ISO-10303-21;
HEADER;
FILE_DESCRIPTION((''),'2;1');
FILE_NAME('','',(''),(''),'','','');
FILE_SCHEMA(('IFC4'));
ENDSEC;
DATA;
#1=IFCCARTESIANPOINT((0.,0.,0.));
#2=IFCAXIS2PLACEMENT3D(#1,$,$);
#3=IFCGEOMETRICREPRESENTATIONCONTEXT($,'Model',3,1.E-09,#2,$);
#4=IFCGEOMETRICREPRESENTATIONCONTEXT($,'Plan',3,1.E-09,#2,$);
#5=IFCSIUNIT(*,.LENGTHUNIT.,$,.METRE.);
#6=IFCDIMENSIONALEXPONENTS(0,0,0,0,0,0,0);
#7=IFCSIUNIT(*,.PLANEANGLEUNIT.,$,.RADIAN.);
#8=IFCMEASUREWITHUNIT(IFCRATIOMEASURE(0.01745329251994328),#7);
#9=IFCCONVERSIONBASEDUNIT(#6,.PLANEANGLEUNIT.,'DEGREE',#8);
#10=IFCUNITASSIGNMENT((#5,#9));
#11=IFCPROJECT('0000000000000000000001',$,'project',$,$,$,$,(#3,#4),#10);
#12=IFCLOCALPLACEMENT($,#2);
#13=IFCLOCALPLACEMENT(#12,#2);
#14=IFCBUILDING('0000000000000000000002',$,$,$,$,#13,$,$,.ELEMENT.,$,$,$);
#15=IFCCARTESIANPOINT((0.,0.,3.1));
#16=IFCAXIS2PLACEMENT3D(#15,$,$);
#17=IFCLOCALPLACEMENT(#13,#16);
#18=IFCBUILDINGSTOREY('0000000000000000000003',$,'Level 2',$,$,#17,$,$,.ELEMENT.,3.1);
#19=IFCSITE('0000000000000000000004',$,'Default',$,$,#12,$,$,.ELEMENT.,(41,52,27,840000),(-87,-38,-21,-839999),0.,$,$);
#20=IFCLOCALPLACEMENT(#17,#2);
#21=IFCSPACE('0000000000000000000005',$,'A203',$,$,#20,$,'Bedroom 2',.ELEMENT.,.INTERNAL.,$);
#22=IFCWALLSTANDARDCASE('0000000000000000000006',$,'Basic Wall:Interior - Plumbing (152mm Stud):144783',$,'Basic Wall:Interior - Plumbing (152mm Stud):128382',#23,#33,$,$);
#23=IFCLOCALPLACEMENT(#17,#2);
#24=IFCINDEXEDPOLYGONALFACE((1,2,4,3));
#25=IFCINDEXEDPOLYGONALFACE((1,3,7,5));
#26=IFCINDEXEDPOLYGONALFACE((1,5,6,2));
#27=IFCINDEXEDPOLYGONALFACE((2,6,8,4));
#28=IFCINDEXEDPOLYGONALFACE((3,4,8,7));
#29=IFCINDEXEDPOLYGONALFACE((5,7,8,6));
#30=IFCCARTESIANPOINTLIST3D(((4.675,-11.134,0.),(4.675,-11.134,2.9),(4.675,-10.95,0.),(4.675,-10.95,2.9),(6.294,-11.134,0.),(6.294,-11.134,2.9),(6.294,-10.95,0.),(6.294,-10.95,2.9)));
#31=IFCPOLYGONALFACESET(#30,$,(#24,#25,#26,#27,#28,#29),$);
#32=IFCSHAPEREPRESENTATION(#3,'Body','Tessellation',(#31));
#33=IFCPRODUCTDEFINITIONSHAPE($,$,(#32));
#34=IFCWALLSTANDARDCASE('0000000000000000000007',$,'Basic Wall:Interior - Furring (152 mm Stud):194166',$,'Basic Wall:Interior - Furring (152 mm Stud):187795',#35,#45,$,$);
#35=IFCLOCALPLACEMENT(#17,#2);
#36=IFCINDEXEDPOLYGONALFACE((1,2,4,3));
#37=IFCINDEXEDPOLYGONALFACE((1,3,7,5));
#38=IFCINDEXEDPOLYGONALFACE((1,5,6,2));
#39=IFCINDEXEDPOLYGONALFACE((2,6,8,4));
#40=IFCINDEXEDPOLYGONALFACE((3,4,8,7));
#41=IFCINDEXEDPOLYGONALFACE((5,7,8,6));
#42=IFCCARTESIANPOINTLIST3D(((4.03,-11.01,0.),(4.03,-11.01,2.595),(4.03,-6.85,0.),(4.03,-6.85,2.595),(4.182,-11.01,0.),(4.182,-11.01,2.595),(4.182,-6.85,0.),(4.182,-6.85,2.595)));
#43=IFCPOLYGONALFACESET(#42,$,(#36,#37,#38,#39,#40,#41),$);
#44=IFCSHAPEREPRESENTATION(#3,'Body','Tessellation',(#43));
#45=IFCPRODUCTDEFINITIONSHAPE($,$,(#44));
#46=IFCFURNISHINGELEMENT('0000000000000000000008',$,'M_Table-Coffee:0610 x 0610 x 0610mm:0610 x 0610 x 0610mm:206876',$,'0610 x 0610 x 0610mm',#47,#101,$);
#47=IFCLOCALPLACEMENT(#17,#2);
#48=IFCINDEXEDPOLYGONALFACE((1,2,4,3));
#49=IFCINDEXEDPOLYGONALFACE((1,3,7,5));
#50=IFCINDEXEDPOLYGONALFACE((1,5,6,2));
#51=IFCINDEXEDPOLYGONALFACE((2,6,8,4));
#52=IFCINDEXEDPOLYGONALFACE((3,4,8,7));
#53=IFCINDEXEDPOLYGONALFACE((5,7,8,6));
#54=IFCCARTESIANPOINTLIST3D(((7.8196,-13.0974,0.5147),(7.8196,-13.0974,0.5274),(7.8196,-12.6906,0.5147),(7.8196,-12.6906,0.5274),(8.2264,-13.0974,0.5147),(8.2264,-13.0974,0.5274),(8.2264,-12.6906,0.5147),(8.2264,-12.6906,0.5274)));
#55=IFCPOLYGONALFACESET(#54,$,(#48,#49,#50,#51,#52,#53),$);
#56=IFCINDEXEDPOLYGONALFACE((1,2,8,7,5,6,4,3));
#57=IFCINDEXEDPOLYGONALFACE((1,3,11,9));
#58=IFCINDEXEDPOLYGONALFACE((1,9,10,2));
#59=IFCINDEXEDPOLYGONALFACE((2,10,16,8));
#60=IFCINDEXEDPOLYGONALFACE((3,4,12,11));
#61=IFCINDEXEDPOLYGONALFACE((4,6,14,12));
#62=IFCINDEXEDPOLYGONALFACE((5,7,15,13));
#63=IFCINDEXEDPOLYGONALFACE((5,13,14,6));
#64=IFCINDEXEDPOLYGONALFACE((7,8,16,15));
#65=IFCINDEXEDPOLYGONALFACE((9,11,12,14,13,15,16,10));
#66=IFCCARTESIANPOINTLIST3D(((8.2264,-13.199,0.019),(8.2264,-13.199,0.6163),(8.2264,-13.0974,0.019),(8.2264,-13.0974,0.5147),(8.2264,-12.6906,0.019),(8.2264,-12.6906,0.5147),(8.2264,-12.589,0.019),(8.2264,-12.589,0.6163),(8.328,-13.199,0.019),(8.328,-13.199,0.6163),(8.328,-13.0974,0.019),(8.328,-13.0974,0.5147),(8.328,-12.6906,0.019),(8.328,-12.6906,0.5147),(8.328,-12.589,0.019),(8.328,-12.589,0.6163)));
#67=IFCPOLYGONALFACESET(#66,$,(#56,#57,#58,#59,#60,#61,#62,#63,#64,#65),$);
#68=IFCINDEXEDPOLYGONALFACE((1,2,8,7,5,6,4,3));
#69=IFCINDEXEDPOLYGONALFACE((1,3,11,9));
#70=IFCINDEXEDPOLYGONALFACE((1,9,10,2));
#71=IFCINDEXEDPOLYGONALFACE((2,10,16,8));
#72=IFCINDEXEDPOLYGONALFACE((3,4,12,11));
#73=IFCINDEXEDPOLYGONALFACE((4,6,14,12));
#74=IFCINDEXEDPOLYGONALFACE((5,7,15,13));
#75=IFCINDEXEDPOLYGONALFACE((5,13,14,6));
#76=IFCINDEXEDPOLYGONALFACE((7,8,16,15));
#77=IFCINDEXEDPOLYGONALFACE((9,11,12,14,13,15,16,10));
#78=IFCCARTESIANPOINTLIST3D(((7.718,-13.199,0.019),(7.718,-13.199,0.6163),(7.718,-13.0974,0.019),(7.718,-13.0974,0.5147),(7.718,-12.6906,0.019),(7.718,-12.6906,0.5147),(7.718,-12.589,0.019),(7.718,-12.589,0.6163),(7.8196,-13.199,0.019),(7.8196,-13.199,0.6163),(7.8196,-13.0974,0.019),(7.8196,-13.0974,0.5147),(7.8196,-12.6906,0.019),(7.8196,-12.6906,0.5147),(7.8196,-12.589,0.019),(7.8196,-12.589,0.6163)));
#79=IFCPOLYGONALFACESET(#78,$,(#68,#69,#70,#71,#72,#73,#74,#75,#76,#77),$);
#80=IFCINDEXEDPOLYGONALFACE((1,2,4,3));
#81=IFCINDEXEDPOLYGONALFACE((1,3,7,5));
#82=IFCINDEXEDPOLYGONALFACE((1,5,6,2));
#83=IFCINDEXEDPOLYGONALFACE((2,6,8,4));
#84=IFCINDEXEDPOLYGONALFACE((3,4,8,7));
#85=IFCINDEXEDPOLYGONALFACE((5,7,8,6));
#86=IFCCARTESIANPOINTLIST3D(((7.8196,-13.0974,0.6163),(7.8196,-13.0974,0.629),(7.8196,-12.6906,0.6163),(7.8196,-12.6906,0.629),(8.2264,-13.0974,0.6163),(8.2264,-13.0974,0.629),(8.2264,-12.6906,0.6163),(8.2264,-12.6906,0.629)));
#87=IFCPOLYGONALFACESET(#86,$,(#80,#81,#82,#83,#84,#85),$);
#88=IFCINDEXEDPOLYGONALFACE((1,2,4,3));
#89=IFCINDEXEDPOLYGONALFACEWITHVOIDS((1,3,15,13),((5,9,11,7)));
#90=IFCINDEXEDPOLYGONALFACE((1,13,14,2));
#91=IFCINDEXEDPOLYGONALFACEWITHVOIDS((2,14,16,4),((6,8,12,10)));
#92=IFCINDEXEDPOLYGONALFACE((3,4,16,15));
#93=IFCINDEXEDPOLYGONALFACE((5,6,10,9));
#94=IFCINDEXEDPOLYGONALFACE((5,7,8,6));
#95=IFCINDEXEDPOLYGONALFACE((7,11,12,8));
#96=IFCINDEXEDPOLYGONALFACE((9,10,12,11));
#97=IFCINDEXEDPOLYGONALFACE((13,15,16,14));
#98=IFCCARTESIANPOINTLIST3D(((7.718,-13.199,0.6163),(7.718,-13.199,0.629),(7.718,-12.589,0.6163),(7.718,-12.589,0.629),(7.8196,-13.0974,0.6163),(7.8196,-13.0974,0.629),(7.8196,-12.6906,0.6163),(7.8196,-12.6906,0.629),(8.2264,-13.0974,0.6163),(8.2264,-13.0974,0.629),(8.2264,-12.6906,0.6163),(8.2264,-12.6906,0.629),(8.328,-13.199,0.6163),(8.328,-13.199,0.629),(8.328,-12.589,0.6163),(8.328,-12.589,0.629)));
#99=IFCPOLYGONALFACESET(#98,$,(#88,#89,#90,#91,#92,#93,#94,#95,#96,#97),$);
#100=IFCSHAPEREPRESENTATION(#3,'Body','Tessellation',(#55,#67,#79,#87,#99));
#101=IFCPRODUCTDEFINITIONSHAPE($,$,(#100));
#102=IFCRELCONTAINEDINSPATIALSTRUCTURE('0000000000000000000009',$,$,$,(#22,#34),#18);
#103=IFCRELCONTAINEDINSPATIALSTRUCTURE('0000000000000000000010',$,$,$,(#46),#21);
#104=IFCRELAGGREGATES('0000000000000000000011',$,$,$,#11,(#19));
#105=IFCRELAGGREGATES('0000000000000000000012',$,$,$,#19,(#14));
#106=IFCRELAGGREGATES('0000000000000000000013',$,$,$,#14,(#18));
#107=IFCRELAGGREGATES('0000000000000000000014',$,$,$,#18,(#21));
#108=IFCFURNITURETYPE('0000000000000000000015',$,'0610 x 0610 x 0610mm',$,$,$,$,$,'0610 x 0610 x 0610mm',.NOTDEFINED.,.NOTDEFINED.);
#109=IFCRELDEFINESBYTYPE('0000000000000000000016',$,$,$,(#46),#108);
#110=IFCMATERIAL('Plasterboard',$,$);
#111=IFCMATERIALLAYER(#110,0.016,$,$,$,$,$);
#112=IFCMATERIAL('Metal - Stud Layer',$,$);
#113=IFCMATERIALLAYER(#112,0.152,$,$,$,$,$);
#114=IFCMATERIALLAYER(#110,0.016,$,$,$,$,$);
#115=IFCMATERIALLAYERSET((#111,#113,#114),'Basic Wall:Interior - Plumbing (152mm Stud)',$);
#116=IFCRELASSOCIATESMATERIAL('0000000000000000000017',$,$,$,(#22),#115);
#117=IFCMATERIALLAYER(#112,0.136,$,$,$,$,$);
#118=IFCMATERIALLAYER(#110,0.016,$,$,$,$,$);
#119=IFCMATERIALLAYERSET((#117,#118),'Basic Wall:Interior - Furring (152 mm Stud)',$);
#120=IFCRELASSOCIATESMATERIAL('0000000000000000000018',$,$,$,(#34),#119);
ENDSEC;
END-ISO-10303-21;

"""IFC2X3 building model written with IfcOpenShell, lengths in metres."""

from ifc_helpers import new_model, entity, si_unit, converted_unit, frame, frame_2d, origin, origin_2d_with_axis, place, context, project, spatial, polyline, rectangle, outline, extrude, source, transform, mapped, material, layer, layer_set, layer_usage, type_object, type_shapes, element, save


model = new_model("IFC2X3")

# Units and contexts
model_context = context("Model", 3, precision=1e-09, world=origin())
plan_context = context("Plan", 3, precision=1e-09, world=origin())
ifc_project = project(units=[si_unit("LENGTHUNIT", "METRE"), converted_unit("PLANEANGLEUNIT", "DEGREE", entity("IfcRatioMeasure", 0.01745329251994328), si_unit("PLANEANGLEUNIT", "RADIAN"), dimensions=[0, 0, 0, 0, 0, 0, 0])], contexts=[model_context, plan_context])

# Site, building, storey
site_placement = place(None, origin())
site = spatial("IfcSite", under=ifc_project, at=site_placement, Name="Default", CompositionType="ELEMENT", RefLatitude=(41, 52, 27, 840000), RefLongitude=(-87, -38, -21, -839999), RefElevation=0.0)
building_placement = place(site_placement, origin())
building = spatial("IfcBuilding", under=site, at=building_placement, CompositionType="ELEMENT")
storey_placement = place(building_placement, frame((0.0, 0.0, 3.1)))
storey = spatial("IfcBuildingStorey", under=building, at=storey_placement, Name="Level 2", CompositionType="ELEMENT", Elevation=3.1)

# Shared definitions
ifc_material_1 = material(Name="Metal - Stud Layer")
ifc_material_2 = material(Name="Plasterboard")

# Walls
ifc_layer_1 = layer(ifc_material_2, 0.016)
ifc_layer_2 = layer(ifc_material_1, 0.152)
ifc_layer_3 = layer(ifc_material_2, 0.016)
ifc_layer_set_1 = layer_set([ifc_layer_1, ifc_layer_2, ifc_layer_3], Name="Basic Wall:Interior - Plumbing (152mm Stud)")
ifc_layer_usage_1 = layer_usage(ifc_layer_set_1, "AXIS2", "NEGATIVE", 0.092)
wall_1_placement = place(storey_placement, frame((6.294, -11.042, 0.0), z_axis=(0.0, 0.0, 1.0), x_axis=(-1.0, 0.0, 0.0)))
element("IfcWallStandardCase", 1, at=wall_1_placement, inside=storey, material=ifc_layer_usage_1, Name="Basic Wall:Interior - Plumbing (152mm Stud):144783", ObjectType="Basic Wall:Interior - Plumbing (152mm Stud):128382", context=model_context, shape_type="SweptSolid", body=[
    extrude(rectangle(XDim=1.619, YDim=0.184, at=frame_2d((0.8095, 0.0), x_axis=(-1.0, 0.0))), origin(), (0.0, 0.0, 1.0), 2.9),
])
ifc_layer_4 = layer(ifc_material_1, 0.136)
ifc_layer_5 = layer(ifc_material_2, 0.016)
ifc_layer_set_2 = layer_set([ifc_layer_4, ifc_layer_5], Name="Basic Wall:Interior - Furring (152 mm Stud)")
ifc_layer_usage_2 = layer_usage(ifc_layer_set_2, "AXIS2", "POSITIVE", -0.076)
wall_2_placement = place(storey_placement, frame((4.106, -11.01, 0.0), z_axis=(0.0, 0.0, 1.0), x_axis=(0.0, 1.0, 0.0)))
element("IfcWallStandardCase", 2, at=wall_2_placement, inside=storey, material=ifc_layer_usage_2, Name="Basic Wall:Interior - Furring (152 mm Stud):194166", ObjectType="Basic Wall:Interior - Furring (152 mm Stud):187795", context=model_context, shape_type="SweptSolid", body=[
    extrude(rectangle(XDim=4.16, YDim=0.152, at=frame_2d((2.08, 0.0), x_axis=(-1.0, 0.0))), origin(), (0.0, 0.0, 1.0), 2.595),
])

# Shared definitions
space_placement = place(storey_placement, origin())
space = spatial("IfcSpace", under=storey, at=space_placement, Name="A203", LongName="Bedroom 2", CompositionType="ELEMENT", InteriorOrExteriorSpace="INTERNAL")

# Furnishing element
furniture_type = type_object("IfcFurnitureType", Name="0610 x 0610 x 0610mm", ElementType="0610 x 0610 x 0610mm", AssemblyPlace="NOTDEFINED")
shared_shape_1 = source(origin(), model_context, "Body", "SweptSolid", [
    extrude(rectangle(XDim=0.4068, YDim=0.4068, at=origin_2d_with_axis()), frame((0.0183, 0.0952, 0.4957), z_axis=(0.0, 0.0, 1.0), x_axis=(-1.0, 0.0, 0.0)), (0.0, 0.0, 1.0), 0.0127),
    extrude(outline(polyline([(-0.2732, -0.305), (0.324, -0.305), (0.324, 0.305), (-0.2732, 0.305), (-0.2732, 0.2034), (0.2225, 0.2034), (0.2225, -0.2034), (-0.2732, -0.2034), (-0.2732, -0.305)])), frame((0.2217, 0.0952, 0.2732), z_axis=(1.0, 0.0, 0.0), x_axis=(0.0, 0.0, 1.0)), (0.0, 0.0, 1.0), 0.1016),
    extrude(outline(polyline([(-0.305, -0.3241), (0.305, -0.3241), (0.305, 0.2733), (0.2034, 0.2733), (0.2034, -0.2224), (-0.2034, -0.2224), (-0.2034, 0.2733), (-0.305, 0.2733), (-0.305, -0.3241)])), frame((-0.2867, 0.0952, 0.2733), z_axis=(1.0, 0.0, 0.0), x_axis=(0.0, -1.0, 0.0)), (0.0, 0.0, 1.0), 0.1016),
    extrude(rectangle(XDim=0.4068, YDim=0.4068, at=origin_2d_with_axis()), frame((0.0183, 0.0952, 0.5973), z_axis=(0.0, 0.0, 1.0), x_axis=(-1.0, 0.0, 0.0)), (0.0, 0.0, 1.0), 0.0127),
    extrude(outline(polyline([(-0.305, -0.305), (0.305, -0.305), (0.305, 0.305), (-0.305, 0.305), (-0.305, -0.305)]), holes=[polyline([(-0.2034, -0.2034), (-0.2034, 0.2034), (0.2034, 0.2034), (0.2034, -0.2034), (-0.2034, -0.2034)])]), frame((0.0183, 0.0952, 0.5973), z_axis=(0.0, 0.0, 1.0), x_axis=(-1.0, 0.0, 0.0)), (0.0, 0.0, 1.0), 0.0127),
])
type_shapes(furniture_type, [shared_shape_1])
furnishing_placement = place(space_placement, frame((8.0047, -12.9892, 0.019)))
element("IfcFurnishingElement", 3, at=furnishing_placement, inside=space, type_object=furniture_type, Name="M_Table-Coffee:0610 x 0610 x 0610mm:0610 x 0610 x 0610mm:206876", ObjectType="0610 x 0610 x 0610mm", context=model_context, shape_type="MappedRepresentation", body=[
    mapped(shared_shape_1, transform((0.0, 0.0, 0.0), scale=1.0)),
])

save(model, "model.ifc")
